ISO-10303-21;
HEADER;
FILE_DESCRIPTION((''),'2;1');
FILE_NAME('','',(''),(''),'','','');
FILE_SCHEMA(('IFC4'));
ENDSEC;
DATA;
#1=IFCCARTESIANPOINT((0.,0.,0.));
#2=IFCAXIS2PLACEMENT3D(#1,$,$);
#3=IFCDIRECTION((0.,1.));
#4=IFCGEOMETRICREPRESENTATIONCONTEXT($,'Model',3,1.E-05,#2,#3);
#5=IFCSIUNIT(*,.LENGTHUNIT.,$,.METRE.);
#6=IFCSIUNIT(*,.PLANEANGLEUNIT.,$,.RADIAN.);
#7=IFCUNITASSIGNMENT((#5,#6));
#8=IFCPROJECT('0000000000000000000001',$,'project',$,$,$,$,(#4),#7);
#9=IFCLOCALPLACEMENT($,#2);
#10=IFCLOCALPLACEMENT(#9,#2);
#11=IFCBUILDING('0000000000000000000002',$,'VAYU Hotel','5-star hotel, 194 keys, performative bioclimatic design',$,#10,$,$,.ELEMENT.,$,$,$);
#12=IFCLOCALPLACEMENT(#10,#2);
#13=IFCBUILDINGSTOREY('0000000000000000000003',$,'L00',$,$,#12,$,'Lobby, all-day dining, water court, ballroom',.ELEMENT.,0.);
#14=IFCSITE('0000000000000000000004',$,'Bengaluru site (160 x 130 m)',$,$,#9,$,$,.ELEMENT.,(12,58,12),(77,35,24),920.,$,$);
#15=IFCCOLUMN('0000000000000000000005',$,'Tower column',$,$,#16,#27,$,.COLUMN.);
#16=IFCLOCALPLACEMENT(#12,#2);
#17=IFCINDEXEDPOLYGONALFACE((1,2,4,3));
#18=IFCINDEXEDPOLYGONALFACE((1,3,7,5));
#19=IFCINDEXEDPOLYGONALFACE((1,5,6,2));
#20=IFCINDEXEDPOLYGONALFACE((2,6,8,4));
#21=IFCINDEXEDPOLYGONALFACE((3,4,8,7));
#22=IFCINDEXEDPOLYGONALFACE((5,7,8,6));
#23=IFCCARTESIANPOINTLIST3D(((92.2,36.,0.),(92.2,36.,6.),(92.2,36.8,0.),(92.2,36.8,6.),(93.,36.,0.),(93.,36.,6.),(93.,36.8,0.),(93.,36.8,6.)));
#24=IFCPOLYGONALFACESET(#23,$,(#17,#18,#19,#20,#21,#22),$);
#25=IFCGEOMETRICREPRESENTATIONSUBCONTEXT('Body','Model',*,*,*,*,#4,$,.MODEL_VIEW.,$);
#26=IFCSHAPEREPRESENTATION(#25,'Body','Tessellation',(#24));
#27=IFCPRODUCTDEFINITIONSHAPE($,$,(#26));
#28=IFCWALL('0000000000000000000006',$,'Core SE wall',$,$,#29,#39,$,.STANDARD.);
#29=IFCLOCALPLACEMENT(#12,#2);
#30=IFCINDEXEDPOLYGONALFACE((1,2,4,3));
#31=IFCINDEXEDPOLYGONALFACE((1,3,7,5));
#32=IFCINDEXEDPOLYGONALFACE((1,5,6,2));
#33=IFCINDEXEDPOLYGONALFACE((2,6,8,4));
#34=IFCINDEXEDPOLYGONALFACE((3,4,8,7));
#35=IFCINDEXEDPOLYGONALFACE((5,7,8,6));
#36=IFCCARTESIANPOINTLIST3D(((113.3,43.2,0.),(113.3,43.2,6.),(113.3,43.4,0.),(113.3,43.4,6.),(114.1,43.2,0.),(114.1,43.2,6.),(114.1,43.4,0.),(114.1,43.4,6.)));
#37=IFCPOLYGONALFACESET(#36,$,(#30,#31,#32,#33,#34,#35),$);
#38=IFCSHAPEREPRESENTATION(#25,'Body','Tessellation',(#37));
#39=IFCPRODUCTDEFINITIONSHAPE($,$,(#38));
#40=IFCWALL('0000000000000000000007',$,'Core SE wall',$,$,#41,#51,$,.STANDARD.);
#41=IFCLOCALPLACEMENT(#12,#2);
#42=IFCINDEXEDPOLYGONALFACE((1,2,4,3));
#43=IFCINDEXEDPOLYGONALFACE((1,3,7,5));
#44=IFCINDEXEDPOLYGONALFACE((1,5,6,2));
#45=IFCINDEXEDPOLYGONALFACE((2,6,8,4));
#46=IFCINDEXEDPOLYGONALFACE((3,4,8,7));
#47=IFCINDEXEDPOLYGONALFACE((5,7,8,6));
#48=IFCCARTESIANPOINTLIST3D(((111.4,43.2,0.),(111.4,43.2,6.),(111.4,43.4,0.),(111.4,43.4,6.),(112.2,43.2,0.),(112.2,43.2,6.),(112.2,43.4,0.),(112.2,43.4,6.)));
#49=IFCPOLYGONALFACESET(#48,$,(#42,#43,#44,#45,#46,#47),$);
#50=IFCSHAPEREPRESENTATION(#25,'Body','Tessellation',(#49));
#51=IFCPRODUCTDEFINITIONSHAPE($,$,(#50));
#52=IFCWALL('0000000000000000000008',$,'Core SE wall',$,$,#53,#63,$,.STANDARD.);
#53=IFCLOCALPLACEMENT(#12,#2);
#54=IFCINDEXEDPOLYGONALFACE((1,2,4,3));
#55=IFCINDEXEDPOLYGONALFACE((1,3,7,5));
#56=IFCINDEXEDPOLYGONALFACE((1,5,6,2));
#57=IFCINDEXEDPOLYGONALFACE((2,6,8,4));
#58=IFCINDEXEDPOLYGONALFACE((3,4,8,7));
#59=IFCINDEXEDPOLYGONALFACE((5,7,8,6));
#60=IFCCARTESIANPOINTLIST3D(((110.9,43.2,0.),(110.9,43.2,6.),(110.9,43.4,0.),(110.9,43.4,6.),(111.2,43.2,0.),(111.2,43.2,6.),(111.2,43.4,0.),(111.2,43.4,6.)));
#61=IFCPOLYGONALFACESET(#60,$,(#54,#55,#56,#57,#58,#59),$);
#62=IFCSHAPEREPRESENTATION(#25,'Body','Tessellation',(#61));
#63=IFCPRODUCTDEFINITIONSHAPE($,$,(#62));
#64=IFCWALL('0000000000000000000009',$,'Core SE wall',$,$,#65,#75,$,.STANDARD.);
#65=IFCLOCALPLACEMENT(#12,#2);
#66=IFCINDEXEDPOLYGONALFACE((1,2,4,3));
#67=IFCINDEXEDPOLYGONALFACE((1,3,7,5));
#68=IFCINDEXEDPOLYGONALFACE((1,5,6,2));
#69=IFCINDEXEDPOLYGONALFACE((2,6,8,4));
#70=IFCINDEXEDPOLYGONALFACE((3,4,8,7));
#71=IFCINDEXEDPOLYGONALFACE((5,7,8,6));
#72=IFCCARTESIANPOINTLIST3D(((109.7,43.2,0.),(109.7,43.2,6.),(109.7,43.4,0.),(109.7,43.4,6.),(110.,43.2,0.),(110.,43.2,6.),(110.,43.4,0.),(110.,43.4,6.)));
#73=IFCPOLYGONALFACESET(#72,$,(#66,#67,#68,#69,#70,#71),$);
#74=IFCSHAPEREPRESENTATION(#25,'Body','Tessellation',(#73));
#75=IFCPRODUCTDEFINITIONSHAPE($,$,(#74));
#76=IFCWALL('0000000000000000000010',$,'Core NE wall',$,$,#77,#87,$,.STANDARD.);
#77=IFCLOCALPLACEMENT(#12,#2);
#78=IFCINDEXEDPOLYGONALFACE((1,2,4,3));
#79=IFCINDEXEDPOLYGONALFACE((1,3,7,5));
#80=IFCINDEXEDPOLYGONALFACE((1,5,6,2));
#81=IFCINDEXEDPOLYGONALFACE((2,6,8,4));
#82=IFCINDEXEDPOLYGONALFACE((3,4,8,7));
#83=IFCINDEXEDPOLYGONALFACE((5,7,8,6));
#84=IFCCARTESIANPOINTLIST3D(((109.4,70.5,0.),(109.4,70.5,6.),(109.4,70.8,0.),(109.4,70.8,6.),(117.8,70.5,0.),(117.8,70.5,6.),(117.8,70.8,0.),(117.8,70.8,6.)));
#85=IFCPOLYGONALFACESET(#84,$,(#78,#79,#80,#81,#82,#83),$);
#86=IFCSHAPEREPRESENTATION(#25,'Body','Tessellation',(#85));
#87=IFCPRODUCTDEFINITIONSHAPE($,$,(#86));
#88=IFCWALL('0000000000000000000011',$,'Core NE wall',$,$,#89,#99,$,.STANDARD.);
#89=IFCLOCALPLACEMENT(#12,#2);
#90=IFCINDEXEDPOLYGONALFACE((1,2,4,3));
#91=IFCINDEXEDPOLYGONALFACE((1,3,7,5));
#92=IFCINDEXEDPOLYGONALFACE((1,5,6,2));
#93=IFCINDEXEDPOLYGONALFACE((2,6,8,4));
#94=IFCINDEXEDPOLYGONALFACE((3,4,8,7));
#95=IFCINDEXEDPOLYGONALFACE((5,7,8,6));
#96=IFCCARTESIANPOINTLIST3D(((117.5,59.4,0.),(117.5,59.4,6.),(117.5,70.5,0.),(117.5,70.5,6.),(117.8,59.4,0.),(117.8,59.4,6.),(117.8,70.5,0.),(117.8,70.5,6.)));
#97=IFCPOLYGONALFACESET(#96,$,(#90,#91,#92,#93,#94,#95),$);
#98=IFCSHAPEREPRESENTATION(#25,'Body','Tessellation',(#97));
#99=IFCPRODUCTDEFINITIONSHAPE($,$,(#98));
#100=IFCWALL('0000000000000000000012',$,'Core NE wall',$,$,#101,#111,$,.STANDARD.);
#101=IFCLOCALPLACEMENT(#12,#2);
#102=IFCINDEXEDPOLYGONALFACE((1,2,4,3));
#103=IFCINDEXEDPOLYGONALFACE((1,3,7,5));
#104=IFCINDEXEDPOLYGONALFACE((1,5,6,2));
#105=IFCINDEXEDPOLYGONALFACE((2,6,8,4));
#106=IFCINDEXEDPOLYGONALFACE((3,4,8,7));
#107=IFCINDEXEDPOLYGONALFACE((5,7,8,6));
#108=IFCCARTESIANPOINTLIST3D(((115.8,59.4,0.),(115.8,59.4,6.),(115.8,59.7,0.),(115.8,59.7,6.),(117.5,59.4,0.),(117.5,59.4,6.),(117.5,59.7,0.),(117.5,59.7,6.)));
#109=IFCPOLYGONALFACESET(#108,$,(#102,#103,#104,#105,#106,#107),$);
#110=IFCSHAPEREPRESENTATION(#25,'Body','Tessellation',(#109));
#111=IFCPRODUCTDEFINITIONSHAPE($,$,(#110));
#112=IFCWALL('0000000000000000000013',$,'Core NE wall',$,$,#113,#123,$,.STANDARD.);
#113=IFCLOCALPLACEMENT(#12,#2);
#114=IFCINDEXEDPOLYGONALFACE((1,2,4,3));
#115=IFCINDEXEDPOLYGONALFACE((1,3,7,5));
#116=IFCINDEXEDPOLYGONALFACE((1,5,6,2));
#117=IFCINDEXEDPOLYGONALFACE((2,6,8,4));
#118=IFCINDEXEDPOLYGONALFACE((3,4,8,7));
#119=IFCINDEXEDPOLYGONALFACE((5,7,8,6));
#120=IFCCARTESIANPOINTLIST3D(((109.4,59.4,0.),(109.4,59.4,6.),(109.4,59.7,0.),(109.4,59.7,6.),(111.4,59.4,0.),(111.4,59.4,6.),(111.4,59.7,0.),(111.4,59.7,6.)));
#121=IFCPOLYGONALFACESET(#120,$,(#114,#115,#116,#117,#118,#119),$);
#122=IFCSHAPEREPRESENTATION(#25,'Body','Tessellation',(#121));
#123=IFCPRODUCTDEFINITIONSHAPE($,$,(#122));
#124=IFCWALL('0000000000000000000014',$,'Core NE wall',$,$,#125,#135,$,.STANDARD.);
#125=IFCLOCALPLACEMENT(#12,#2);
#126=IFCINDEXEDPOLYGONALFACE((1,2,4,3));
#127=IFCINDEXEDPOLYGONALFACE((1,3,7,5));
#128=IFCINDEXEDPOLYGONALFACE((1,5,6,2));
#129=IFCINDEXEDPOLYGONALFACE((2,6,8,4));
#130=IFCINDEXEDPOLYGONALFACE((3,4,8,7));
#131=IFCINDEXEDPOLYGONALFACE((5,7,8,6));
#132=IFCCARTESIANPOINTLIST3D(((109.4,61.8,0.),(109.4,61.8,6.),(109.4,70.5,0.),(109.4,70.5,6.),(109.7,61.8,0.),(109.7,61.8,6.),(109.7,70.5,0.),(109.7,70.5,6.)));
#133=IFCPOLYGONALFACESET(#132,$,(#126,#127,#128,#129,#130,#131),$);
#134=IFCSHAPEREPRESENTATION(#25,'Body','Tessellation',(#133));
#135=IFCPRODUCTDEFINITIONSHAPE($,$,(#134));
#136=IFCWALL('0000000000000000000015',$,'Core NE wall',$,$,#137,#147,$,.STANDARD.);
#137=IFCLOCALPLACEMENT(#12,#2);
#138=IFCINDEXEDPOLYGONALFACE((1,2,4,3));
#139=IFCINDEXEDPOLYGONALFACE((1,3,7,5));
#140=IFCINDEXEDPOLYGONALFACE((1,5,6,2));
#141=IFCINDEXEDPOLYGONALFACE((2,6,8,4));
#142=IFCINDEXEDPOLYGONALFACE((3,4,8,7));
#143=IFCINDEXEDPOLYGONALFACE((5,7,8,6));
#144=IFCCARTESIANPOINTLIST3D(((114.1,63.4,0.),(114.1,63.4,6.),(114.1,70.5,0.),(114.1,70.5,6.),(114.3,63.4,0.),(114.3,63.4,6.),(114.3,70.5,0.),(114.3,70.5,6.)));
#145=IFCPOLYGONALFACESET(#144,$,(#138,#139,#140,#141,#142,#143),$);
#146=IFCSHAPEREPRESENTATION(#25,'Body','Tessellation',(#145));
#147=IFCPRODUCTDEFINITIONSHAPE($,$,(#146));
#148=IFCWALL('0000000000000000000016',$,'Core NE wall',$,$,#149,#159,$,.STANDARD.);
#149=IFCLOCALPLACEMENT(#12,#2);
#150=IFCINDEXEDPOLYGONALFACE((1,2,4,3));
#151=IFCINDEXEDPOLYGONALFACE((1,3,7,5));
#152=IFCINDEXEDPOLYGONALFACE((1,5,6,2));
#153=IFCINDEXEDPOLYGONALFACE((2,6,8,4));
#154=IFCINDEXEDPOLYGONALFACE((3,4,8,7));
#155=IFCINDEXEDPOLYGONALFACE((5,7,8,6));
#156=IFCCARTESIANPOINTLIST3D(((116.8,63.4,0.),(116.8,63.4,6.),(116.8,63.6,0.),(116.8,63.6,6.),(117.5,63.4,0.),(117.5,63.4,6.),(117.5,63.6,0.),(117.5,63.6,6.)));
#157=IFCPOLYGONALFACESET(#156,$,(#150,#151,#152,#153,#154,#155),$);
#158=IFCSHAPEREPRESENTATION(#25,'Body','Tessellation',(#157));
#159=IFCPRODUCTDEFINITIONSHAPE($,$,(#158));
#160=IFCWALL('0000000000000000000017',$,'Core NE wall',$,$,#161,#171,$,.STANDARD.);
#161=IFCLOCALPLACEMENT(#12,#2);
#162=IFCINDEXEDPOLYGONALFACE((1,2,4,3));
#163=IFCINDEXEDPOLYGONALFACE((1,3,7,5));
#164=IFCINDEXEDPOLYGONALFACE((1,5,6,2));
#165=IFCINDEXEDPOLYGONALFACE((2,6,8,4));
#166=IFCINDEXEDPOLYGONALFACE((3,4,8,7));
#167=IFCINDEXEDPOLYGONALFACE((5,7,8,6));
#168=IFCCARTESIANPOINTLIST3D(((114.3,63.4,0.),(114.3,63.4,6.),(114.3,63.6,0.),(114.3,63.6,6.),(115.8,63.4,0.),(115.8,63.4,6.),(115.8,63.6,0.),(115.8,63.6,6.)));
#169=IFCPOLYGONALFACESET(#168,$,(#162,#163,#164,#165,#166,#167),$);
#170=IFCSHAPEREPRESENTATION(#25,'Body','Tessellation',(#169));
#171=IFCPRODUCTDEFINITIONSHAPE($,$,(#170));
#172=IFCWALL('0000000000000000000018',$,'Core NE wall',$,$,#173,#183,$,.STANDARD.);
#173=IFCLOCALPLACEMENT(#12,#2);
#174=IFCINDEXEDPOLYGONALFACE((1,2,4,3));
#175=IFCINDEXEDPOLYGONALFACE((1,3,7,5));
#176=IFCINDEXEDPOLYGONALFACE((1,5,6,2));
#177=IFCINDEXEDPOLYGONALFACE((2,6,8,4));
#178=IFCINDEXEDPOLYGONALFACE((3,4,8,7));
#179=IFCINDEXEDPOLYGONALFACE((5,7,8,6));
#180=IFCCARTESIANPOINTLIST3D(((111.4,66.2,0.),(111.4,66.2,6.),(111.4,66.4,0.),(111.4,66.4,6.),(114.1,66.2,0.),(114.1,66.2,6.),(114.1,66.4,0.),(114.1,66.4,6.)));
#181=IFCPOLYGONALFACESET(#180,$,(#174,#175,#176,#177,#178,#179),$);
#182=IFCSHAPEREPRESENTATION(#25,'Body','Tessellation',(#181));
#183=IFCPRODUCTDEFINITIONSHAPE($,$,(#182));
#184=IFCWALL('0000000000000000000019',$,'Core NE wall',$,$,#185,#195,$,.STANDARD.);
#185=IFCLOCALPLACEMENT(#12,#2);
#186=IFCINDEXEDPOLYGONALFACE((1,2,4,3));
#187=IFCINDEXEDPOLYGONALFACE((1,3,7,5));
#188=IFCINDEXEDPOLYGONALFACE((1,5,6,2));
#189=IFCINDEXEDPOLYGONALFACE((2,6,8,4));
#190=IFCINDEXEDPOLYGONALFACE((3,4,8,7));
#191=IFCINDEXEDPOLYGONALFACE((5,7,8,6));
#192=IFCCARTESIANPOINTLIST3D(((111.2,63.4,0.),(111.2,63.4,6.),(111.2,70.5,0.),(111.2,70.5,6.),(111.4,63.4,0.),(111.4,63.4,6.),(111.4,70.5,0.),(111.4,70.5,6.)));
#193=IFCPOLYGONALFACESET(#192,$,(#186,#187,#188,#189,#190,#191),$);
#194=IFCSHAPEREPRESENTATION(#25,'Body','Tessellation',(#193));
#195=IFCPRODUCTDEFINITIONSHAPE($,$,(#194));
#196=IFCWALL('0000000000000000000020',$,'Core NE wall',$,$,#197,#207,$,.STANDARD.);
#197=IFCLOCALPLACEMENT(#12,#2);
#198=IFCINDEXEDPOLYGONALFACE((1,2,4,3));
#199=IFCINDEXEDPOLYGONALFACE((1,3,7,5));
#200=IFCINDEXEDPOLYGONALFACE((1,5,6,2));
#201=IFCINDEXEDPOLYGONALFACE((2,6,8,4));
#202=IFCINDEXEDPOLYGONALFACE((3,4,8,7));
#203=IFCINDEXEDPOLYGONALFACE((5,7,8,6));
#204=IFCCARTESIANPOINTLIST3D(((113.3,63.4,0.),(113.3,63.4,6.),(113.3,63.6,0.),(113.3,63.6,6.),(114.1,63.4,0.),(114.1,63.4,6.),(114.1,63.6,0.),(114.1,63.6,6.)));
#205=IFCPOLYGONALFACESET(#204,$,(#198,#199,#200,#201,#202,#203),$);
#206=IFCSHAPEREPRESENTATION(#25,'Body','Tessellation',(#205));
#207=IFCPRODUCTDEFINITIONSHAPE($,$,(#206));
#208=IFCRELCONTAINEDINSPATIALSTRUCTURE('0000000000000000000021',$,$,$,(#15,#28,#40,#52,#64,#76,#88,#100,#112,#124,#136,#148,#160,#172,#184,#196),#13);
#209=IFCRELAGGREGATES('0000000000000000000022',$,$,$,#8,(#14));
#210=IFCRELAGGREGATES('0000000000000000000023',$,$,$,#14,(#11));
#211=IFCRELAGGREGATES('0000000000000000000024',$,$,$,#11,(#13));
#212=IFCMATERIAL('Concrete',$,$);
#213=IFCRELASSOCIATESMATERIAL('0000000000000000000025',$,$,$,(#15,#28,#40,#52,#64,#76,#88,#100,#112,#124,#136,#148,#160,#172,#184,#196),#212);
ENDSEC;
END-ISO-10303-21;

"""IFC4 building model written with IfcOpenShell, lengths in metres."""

from ifc_helpers import new_model, si_unit, direction, origin, place, context, subcontext, project, spatial, polyline, outline, extrude, material, element, save


model = new_model("IFC4")

# Units and contexts
model_context = context("Model", 3, precision=1e-05, world=origin(), true_north=direction((0.0, 1.0)))
body_context = subcontext(model_context, "Body", "Model", "MODEL_VIEW")
ifc_project = project(units=[si_unit("LENGTHUNIT", "METRE"), si_unit("PLANEANGLEUNIT", "RADIAN")], contexts=[model_context])

# Site, building, storey
site_placement = place(None, origin())
site = spatial("IfcSite", under=ifc_project, at=site_placement, Name="Bengaluru site (160 x 130 m)", CompositionType="ELEMENT", RefLatitude=(12, 58, 12), RefLongitude=(77, 35, 24), RefElevation=920.0)
building_placement = place(site_placement, origin())
building = spatial("IfcBuilding", under=site, at=building_placement, Name="VAYU Hotel", Description="5-star hotel, 194 keys, performative bioclimatic design", CompositionType="ELEMENT")
storey_placement = place(building_placement, origin())
storey = spatial("IfcBuildingStorey", under=building, at=storey_placement, Name="L00", LongName="Lobby, all-day dining, water court, ballroom", CompositionType="ELEMENT", Elevation=0.0)

# Column
ifc_material_1 = material(Name="Concrete")
column_1_placement = place(storey_placement, origin())
element("IfcColumn", 1, at=column_1_placement, inside=storey, material=ifc_material_1, Name="Tower column", PredefinedType="COLUMN", context=body_context, shape_type="SweptSolid", body=[
    extrude(outline(polyline([(92.2, 36.0), (93.0, 36.0), (93.0, 36.8), (92.2, 36.8), (92.2, 36.0)])), origin(), (0.0, 0.0, 1.0), 6.0),
])

# Walls
wall_1_placement = place(storey_placement, origin())
element("IfcWall", 2, at=wall_1_placement, inside=storey, material=ifc_material_1, Name="Core SE wall", PredefinedType="STANDARD", context=body_context, shape_type="SweptSolid", body=[
    extrude(outline(polyline([(113.3, 43.4), (114.1, 43.4), (114.1, 43.2), (113.3, 43.2), (113.3, 43.4)])), origin(), (0.0, 0.0, 1.0), 6.0),
])
wall_2_placement = place(storey_placement, origin())
element("IfcWall", 3, at=wall_2_placement, inside=storey, material=ifc_material_1, Name="Core SE wall", PredefinedType="STANDARD", context=body_context, shape_type="SweptSolid", body=[
    extrude(outline(polyline([(111.4, 43.4), (112.2, 43.4), (112.2, 43.2), (111.4, 43.2), (111.4, 43.4)])), origin(), (0.0, 0.0, 1.0), 6.0),
])
wall_3_placement = place(storey_placement, origin())
element("IfcWall", 4, at=wall_3_placement, inside=storey, material=ifc_material_1, Name="Core SE wall", PredefinedType="STANDARD", context=body_context, shape_type="SweptSolid", body=[
    extrude(outline(polyline([(110.9, 43.4), (111.2, 43.4), (111.2, 43.2), (110.9, 43.2), (110.9, 43.4)])), origin(), (0.0, 0.0, 1.0), 6.0),
])
wall_4_placement = place(storey_placement, origin())
element("IfcWall", 5, at=wall_4_placement, inside=storey, material=ifc_material_1, Name="Core SE wall", PredefinedType="STANDARD", context=body_context, shape_type="SweptSolid", body=[
    extrude(outline(polyline([(109.7, 43.4), (110.0, 43.4), (110.0, 43.2), (109.7, 43.2), (109.7, 43.4)])), origin(), (0.0, 0.0, 1.0), 6.0),
])
wall_5_placement = place(storey_placement, origin())
element("IfcWall", 6, at=wall_5_placement, inside=storey, material=ifc_material_1, Name="Core NE wall", PredefinedType="STANDARD", context=body_context, shape_type="SweptSolid", body=[
    extrude(outline(polyline([(109.4, 70.8), (117.8, 70.8), (117.8, 70.5), (109.4, 70.5), (109.4, 70.8)])), origin(), (0.0, 0.0, 1.0), 6.0),
])
wall_6_placement = place(storey_placement, origin())
element("IfcWall", 7, at=wall_6_placement, inside=storey, material=ifc_material_1, Name="Core NE wall", PredefinedType="STANDARD", context=body_context, shape_type="SweptSolid", body=[
    extrude(outline(polyline([(117.5, 59.4), (117.5, 70.5), (117.8, 70.5), (117.8, 59.4), (117.5, 59.4)])), origin(), (0.0, 0.0, 1.0), 6.0),
])
wall_7_placement = place(storey_placement, origin())
element("IfcWall", 8, at=wall_7_placement, inside=storey, material=ifc_material_1, Name="Core NE wall", PredefinedType="STANDARD", context=body_context, shape_type="SweptSolid", body=[
    extrude(outline(polyline([(115.8, 59.7), (117.5, 59.7), (117.5, 59.4), (115.8, 59.4), (115.8, 59.7)])), origin(), (0.0, 0.0, 1.0), 6.0),
])
wall_8_placement = place(storey_placement, origin())
element("IfcWall", 9, at=wall_8_placement, inside=storey, material=ifc_material_1, Name="Core NE wall", PredefinedType="STANDARD", context=body_context, shape_type="SweptSolid", body=[
    extrude(outline(polyline([(109.4, 59.7), (111.4, 59.7), (111.4, 59.4), (109.4, 59.4), (109.4, 59.7)])), origin(), (0.0, 0.0, 1.0), 6.0),
])
wall_9_placement = place(storey_placement, origin())
element("IfcWall", 10, at=wall_9_placement, inside=storey, material=ifc_material_1, Name="Core NE wall", PredefinedType="STANDARD", context=body_context, shape_type="SweptSolid", body=[
    extrude(outline(polyline([(109.4, 61.8), (109.4, 70.5), (109.7, 70.5), (109.7, 61.8), (109.4, 61.8)])), origin(), (0.0, 0.0, 1.0), 6.0),
])
wall_10_placement = place(storey_placement, origin())
element("IfcWall", 11, at=wall_10_placement, inside=storey, material=ifc_material_1, Name="Core NE wall", PredefinedType="STANDARD", context=body_context, shape_type="SweptSolid", body=[
    extrude(outline(polyline([(114.1, 63.4), (114.1, 70.5), (114.3, 70.5), (114.3, 63.4), (114.1, 63.4)])), origin(), (0.0, 0.0, 1.0), 6.0),
])
wall_11_placement = place(storey_placement, origin())
element("IfcWall", 12, at=wall_11_placement, inside=storey, material=ifc_material_1, Name="Core NE wall", PredefinedType="STANDARD", context=body_context, shape_type="SweptSolid", body=[
    extrude(outline(polyline([(116.8, 63.6), (117.5, 63.6), (117.5, 63.4), (116.8, 63.4), (116.8, 63.6)])), origin(), (0.0, 0.0, 1.0), 6.0),
])
wall_12_placement = place(storey_placement, origin())
element("IfcWall", 13, at=wall_12_placement, inside=storey, material=ifc_material_1, Name="Core NE wall", PredefinedType="STANDARD", context=body_context, shape_type="SweptSolid", body=[
    extrude(outline(polyline([(114.3, 63.6), (115.8, 63.6), (115.8, 63.4), (114.3, 63.4), (114.3, 63.6)])), origin(), (0.0, 0.0, 1.0), 6.0),
])
wall_13_placement = place(storey_placement, origin())
element("IfcWall", 14, at=wall_13_placement, inside=storey, material=ifc_material_1, Name="Core NE wall", PredefinedType="STANDARD", context=body_context, shape_type="SweptSolid", body=[
    extrude(outline(polyline([(111.4, 66.4), (114.1, 66.4), (114.1, 66.2), (111.4, 66.2), (111.4, 66.4)])), origin(), (0.0, 0.0, 1.0), 6.0),
])
wall_14_placement = place(storey_placement, origin())
element("IfcWall", 15, at=wall_14_placement, inside=storey, material=ifc_material_1, Name="Core NE wall", PredefinedType="STANDARD", context=body_context, shape_type="SweptSolid", body=[
    extrude(outline(polyline([(111.2, 63.4), (111.2, 70.5), (111.4, 70.5), (111.4, 63.4), (111.2, 63.4)])), origin(), (0.0, 0.0, 1.0), 6.0),
])
wall_15_placement = place(storey_placement, origin())
element("IfcWall", 16, at=wall_15_placement, inside=storey, material=ifc_material_1, Name="Core NE wall", PredefinedType="STANDARD", context=body_context, shape_type="SweptSolid", body=[
    extrude(outline(polyline([(113.3, 63.6), (114.1, 63.6), (114.1, 63.4), (113.3, 63.4), (113.3, 63.6)])), origin(), (0.0, 0.0, 1.0), 6.0),
])

save(model, "model.ifc")
